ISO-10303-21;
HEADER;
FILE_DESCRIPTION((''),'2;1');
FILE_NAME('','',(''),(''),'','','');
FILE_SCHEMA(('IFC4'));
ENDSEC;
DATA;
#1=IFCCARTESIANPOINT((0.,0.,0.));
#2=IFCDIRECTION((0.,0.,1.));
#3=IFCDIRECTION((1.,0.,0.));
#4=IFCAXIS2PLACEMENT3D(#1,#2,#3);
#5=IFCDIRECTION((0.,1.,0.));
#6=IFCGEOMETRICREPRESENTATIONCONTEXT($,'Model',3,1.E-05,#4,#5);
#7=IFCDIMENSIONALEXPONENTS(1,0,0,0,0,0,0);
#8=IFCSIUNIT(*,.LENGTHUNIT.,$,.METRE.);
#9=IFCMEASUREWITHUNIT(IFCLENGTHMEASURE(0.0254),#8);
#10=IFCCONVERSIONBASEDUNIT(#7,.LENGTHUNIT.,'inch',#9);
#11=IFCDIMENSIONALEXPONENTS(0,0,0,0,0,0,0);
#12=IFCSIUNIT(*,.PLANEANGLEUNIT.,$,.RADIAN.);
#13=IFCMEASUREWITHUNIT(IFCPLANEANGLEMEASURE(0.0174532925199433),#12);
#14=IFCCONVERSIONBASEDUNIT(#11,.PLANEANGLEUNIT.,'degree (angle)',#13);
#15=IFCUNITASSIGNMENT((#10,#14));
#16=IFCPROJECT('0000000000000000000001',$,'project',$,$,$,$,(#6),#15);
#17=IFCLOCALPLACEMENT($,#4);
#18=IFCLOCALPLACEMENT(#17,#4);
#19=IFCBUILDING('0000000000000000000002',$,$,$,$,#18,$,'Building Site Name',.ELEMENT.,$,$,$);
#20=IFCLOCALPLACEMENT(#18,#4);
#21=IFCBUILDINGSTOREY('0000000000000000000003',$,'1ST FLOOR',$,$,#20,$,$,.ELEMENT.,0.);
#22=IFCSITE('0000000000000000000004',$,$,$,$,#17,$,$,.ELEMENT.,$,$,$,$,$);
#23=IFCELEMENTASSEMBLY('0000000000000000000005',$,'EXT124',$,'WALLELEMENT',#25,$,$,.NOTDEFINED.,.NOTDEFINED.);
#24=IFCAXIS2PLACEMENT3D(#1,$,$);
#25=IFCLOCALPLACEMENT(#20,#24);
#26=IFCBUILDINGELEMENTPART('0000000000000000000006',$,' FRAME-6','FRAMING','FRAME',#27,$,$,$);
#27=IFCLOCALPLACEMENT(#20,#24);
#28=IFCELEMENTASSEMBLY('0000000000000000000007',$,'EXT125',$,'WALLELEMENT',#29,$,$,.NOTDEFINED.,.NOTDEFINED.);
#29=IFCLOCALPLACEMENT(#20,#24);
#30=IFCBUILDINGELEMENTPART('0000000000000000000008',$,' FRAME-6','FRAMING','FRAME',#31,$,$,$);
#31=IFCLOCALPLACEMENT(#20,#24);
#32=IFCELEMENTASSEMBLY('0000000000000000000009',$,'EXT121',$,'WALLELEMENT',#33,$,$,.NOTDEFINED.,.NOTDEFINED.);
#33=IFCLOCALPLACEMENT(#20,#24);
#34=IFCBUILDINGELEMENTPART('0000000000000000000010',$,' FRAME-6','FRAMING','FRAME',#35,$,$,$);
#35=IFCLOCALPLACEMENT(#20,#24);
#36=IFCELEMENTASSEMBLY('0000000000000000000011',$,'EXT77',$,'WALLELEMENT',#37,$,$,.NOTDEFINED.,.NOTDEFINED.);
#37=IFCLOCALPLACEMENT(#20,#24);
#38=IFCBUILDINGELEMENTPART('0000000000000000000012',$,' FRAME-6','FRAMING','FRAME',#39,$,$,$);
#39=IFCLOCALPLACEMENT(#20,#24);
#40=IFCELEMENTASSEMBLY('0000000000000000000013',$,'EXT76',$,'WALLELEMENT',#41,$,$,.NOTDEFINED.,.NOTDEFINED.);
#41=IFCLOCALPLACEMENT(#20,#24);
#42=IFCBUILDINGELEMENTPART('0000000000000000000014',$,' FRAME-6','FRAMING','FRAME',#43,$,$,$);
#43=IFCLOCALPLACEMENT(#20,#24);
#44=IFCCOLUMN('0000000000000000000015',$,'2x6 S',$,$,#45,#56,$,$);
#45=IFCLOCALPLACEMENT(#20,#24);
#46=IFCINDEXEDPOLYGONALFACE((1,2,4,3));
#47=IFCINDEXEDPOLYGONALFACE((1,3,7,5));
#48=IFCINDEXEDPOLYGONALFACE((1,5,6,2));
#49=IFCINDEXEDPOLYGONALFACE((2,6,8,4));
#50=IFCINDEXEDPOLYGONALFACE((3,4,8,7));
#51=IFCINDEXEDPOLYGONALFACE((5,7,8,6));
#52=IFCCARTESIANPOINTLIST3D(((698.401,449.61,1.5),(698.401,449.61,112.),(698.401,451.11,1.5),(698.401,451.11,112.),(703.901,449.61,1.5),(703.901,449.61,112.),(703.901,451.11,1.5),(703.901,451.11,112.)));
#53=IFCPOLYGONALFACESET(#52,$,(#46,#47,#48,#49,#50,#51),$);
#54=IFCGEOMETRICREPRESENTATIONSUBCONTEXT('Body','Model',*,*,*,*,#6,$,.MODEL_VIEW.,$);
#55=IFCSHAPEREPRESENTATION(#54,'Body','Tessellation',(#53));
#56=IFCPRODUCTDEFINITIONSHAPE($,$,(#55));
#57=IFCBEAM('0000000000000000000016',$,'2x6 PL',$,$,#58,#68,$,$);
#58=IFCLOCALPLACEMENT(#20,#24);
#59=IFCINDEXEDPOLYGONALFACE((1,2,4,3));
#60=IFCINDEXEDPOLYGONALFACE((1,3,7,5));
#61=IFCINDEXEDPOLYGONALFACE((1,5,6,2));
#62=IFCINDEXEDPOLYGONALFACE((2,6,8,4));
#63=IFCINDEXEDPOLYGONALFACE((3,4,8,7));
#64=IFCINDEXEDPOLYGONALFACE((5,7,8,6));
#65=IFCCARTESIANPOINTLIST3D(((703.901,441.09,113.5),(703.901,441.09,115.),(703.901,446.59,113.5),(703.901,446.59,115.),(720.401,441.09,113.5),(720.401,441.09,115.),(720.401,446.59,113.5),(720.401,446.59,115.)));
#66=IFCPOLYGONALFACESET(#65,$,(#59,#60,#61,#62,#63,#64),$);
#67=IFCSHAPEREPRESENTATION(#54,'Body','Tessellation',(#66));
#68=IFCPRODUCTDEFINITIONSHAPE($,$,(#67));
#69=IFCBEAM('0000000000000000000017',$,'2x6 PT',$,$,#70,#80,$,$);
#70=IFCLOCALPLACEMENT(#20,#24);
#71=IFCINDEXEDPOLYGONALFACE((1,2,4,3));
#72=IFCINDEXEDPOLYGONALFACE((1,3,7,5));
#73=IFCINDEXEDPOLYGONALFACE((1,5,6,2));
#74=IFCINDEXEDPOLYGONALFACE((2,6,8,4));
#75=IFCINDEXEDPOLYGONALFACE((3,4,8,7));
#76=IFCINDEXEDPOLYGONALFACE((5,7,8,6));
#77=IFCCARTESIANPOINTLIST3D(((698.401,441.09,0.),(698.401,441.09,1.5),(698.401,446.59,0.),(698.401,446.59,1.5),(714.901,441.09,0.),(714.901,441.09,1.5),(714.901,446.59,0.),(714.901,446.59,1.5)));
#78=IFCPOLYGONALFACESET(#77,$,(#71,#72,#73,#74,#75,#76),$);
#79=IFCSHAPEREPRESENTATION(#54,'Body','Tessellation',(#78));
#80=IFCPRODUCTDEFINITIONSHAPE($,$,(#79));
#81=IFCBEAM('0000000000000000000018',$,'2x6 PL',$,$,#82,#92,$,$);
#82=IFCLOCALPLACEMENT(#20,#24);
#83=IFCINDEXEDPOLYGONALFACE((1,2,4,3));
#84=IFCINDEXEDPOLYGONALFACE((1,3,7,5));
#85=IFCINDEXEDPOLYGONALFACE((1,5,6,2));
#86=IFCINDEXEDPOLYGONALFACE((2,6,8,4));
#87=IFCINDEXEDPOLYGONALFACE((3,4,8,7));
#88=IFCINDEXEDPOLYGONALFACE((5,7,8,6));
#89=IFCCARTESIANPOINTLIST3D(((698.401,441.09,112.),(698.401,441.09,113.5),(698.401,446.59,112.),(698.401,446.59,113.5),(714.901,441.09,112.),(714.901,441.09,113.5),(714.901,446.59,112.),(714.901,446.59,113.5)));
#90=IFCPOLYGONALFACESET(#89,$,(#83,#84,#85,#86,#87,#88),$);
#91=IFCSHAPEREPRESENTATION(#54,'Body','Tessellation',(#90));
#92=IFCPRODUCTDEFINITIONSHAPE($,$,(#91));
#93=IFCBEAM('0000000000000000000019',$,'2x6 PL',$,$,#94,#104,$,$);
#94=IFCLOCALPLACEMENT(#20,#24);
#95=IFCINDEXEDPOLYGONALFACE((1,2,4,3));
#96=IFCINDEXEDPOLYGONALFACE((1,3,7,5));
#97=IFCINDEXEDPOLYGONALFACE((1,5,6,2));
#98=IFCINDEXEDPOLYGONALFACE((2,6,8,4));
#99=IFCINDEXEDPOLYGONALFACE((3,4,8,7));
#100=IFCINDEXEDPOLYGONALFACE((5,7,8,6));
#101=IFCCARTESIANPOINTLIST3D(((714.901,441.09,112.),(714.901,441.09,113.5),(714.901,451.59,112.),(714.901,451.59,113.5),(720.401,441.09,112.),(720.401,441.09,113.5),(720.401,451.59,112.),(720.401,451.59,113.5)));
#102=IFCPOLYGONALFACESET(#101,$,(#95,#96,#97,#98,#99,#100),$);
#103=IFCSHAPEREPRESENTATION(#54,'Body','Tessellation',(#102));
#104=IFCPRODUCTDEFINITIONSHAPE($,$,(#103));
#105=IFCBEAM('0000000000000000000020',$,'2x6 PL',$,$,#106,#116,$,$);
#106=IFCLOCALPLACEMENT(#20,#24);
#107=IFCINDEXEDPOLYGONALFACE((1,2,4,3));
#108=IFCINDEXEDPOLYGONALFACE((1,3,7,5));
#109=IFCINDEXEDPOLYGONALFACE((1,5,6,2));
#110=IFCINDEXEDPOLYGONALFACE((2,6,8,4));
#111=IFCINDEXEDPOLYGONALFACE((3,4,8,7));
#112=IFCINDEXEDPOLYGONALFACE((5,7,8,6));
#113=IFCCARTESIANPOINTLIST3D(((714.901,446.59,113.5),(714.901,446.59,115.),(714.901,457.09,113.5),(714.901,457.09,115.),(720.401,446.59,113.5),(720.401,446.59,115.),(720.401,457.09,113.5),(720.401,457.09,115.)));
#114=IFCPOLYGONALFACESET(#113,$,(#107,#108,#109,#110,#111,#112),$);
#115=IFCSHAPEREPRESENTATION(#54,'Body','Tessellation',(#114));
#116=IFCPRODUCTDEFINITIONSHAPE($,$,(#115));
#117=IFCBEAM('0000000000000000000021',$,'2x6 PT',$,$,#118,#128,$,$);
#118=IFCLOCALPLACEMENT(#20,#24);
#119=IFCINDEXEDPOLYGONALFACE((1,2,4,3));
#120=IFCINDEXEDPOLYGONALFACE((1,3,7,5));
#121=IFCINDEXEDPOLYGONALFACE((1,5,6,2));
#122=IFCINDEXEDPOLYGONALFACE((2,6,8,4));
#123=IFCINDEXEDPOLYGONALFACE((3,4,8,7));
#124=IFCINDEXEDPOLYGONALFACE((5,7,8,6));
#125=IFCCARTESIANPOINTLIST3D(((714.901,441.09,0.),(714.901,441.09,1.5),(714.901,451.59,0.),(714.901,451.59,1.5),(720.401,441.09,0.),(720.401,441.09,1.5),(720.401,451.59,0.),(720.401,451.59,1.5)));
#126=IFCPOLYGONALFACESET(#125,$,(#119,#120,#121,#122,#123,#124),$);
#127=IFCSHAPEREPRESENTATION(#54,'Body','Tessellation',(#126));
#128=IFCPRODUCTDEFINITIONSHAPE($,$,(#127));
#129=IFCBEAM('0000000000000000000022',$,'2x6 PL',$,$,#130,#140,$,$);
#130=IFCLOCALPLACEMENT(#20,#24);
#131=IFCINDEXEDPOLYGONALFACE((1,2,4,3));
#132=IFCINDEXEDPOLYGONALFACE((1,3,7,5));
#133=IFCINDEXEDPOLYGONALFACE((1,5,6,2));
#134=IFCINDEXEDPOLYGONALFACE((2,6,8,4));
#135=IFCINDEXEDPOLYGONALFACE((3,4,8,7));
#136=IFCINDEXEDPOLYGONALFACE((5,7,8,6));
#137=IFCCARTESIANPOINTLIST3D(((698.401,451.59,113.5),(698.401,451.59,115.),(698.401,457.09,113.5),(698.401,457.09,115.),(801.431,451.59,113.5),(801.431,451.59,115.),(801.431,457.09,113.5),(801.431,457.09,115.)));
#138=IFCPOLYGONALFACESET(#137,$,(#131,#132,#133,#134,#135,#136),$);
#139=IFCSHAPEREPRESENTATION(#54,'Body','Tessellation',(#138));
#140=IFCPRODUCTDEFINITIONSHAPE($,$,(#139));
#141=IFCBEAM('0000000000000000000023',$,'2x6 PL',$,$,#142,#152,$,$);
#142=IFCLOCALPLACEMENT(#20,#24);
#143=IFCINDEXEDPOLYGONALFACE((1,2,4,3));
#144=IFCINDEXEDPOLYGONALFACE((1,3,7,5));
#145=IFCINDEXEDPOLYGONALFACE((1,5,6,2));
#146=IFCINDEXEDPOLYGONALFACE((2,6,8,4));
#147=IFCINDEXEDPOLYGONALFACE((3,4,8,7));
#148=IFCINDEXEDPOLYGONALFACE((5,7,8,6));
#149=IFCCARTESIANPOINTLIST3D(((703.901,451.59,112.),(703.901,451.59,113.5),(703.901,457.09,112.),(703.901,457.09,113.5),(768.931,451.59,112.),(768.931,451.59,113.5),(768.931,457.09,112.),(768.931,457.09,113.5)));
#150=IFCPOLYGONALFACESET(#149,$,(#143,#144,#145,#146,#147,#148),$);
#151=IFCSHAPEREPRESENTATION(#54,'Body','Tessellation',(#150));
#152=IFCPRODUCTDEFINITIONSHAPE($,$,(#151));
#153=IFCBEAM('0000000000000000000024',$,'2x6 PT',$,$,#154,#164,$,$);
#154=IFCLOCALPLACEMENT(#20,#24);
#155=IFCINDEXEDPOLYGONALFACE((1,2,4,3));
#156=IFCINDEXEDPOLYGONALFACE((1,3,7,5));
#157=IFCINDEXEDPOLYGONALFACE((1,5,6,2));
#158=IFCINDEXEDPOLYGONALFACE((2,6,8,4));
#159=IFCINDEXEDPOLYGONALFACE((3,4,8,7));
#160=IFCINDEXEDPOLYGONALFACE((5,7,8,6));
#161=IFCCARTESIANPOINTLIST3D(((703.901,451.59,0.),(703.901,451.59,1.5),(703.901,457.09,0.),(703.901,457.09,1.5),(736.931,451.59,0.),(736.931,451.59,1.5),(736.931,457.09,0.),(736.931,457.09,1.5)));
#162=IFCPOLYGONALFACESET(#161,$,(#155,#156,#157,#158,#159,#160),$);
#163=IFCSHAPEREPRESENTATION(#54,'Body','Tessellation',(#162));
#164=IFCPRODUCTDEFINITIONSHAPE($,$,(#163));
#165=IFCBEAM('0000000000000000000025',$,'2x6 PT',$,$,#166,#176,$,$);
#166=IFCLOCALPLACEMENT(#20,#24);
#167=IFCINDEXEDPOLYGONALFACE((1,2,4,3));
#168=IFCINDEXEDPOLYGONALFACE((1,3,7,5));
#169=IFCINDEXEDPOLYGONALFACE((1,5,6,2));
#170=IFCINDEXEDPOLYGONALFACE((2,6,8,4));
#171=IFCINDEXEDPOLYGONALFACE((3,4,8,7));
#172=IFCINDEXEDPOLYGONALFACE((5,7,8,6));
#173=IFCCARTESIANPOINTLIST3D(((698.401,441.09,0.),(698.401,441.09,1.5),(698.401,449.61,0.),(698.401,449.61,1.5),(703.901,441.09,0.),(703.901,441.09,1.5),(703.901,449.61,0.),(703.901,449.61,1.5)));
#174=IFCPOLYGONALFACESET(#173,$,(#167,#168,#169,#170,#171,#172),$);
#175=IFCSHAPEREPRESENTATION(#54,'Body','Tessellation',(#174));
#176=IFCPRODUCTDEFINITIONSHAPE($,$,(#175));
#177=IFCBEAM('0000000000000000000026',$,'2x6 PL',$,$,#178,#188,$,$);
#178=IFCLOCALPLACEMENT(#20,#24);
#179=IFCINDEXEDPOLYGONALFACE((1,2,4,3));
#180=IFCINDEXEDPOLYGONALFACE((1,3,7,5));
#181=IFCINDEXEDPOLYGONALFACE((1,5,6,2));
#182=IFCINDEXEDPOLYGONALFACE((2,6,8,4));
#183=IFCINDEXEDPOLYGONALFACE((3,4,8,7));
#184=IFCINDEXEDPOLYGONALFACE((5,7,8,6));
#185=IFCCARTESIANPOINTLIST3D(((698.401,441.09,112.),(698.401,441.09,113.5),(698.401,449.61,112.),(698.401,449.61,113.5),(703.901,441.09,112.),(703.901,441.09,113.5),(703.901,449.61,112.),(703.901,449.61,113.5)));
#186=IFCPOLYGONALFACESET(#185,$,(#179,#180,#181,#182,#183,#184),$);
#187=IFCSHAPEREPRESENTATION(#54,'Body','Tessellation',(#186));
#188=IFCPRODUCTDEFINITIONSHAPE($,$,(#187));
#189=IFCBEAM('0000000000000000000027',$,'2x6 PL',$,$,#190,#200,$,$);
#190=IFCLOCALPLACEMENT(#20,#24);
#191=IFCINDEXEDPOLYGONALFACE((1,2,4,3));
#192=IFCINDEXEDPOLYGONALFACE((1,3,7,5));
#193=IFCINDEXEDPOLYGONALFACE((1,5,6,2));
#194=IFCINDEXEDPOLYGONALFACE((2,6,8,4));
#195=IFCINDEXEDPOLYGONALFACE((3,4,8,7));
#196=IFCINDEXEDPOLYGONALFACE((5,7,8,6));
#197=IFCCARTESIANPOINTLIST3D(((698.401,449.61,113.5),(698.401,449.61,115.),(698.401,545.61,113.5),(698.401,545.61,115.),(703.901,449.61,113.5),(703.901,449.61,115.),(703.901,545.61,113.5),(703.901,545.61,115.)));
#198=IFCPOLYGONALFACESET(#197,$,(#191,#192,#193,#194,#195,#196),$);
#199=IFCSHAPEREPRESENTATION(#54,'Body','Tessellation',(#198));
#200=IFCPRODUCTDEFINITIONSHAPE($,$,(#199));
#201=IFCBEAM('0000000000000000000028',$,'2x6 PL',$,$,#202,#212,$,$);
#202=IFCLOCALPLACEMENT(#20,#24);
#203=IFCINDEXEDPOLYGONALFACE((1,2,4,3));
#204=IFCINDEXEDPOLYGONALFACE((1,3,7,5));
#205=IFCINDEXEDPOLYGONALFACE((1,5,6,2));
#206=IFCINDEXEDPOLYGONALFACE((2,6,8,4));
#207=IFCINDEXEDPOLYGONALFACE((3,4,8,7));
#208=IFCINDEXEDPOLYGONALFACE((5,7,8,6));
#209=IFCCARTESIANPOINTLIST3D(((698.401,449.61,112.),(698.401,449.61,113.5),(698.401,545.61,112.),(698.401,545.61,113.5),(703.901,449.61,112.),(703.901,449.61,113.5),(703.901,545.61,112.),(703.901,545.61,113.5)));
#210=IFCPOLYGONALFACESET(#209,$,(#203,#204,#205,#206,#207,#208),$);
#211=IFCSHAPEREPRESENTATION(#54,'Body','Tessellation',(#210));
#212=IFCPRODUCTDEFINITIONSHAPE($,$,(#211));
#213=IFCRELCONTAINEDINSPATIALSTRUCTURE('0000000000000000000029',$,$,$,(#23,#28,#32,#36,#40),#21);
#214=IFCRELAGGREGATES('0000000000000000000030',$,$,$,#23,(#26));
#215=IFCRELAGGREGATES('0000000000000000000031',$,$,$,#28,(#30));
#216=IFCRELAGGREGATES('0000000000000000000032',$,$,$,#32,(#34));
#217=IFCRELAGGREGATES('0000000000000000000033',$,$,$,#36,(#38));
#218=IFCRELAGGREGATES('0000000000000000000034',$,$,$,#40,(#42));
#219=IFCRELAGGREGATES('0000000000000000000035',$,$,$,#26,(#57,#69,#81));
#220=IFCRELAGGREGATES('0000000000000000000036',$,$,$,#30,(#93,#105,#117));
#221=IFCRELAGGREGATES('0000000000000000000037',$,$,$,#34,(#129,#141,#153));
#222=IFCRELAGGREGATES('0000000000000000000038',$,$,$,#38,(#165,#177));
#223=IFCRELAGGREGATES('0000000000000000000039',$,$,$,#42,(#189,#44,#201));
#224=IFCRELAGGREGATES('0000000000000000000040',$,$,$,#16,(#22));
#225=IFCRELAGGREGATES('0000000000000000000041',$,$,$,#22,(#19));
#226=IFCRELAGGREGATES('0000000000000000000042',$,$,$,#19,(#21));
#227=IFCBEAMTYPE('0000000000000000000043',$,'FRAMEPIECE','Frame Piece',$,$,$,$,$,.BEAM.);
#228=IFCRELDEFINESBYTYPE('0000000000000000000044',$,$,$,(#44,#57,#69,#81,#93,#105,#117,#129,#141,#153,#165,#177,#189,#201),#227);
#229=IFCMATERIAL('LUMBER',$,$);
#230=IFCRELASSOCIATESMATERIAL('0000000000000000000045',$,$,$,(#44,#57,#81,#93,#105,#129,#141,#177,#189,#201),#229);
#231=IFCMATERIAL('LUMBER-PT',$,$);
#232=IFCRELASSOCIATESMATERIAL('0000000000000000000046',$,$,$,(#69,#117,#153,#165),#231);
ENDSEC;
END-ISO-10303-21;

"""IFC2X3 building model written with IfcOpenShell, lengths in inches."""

from ifc_helpers import new_model, entity, si_unit, converted_unit, direction, frame, frame_2d, origin_with_axes, place, context, subcontext, project, spatial, rectangle, extrude, material, type_object, element, aggregate, save


model = new_model("IFC2X3")

# Units and contexts
model_context = context("Model", 3, precision=1e-05, world=origin_with_axes(), true_north=direction((0.0, 1.0, 0.0)))
body_context = subcontext(model_context, "Body", "Model", "MODEL_VIEW")
ifc_project = project(units=[converted_unit("LENGTHUNIT", "inch", entity("IfcLengthMeasure", 0.0254), si_unit("LENGTHUNIT", "METRE"), dimensions=[1, 0, 0, 0, 0, 0, 0]), converted_unit("PLANEANGLEUNIT", "degree (angle)", entity("IfcPlaneAngleMeasure", 0.0174532925199433), si_unit("PLANEANGLEUNIT", "RADIAN"), dimensions=[0, 0, 0, 0, 0, 0, 0])], contexts=[model_context])

# Site, building, storey
site_placement = place(None, origin_with_axes())
site = spatial("IfcSite", under=ifc_project, at=site_placement, CompositionType="ELEMENT")
building_placement = place(site_placement, origin_with_axes())
building = spatial("IfcBuilding", under=site, at=building_placement, LongName="Building Site Name", CompositionType="ELEMENT")
storey_placement = place(building_placement, origin_with_axes())
storey = spatial("IfcBuildingStorey", under=building, at=storey_placement, Name="1ST FLOOR", CompositionType="ELEMENT", Elevation=0.0)

# Element assemblies, building element parts
assembly_1_placement = place(storey_placement, origin_with_axes())
assembly_1 = element("IfcElementAssembly", 1, at=assembly_1_placement, inside=storey, Name="EXT124", ObjectType="WALLELEMENT", AssemblyPlace="NOTDEFINED", PredefinedType="NOTDEFINED")
building_element_part_1 = element("IfcBuildingElementPart", 2, Name=" FRAME-6", Description="FRAMING", ObjectType="FRAME")
aggregate(assembly_1, [building_element_part_1])
ifc_material_1 = material(Name="LUMBER")
beam_type = type_object("IfcBeamType", Name="FRAMEPIECE", Description="Frame Piece", PredefinedType="BEAM")
assembly_2_placement = place(storey_placement, origin_with_axes())
assembly_2 = element("IfcElementAssembly", 3, at=assembly_2_placement, inside=storey, Name="EXT125", ObjectType="WALLELEMENT", AssemblyPlace="NOTDEFINED", PredefinedType="NOTDEFINED")
building_element_part_2 = element("IfcBuildingElementPart", 4, Name=" FRAME-6", Description="FRAMING", ObjectType="FRAME")
aggregate(assembly_2, [building_element_part_2])
assembly_3_placement = place(storey_placement, origin_with_axes())
assembly_3 = element("IfcElementAssembly", 5, at=assembly_3_placement, inside=storey, Name="EXT121", ObjectType="WALLELEMENT", AssemblyPlace="NOTDEFINED", PredefinedType="NOTDEFINED")
building_element_part_3 = element("IfcBuildingElementPart", 6, Name=" FRAME-6", Description="FRAMING", ObjectType="FRAME")
aggregate(assembly_3, [building_element_part_3])
assembly_4_placement = place(storey_placement, origin_with_axes())
assembly_4 = element("IfcElementAssembly", 7, at=assembly_4_placement, inside=storey, Name="EXT77", ObjectType="WALLELEMENT", AssemblyPlace="NOTDEFINED", PredefinedType="NOTDEFINED")
building_element_part_4 = element("IfcBuildingElementPart", 8, Name=" FRAME-6", Description="FRAMING", ObjectType="FRAME")
aggregate(assembly_4, [building_element_part_4])

# Element assembly, building element part, column
assembly_5_placement = place(storey_placement, origin_with_axes())
assembly_5 = element("IfcElementAssembly", 9, at=assembly_5_placement, inside=storey, Name="EXT76", ObjectType="WALLELEMENT", AssemblyPlace="NOTDEFINED", PredefinedType="NOTDEFINED")
building_element_part_5 = element("IfcBuildingElementPart", 10, Name=" FRAME-6", Description="FRAMING", ObjectType="FRAME")
aggregate(assembly_5, [building_element_part_5])
column_1_placement = place(assembly_5_placement, frame((701.151, 450.36, 1.5), z_axis=(0.0, 0.0, 1.0), x_axis=(0.0, 1.0, 0.0)))
column_1 = element("IfcColumn", 11, at=column_1_placement, type_object=beam_type, material=ifc_material_1, Name="2x6 S", context=body_context, shape_type="SweptSolid", body=[
    extrude(rectangle(XDim=1.5, YDim=5.5, at=frame_2d((0.0, 0.0), x_axis=(-1.0, 0.0))), frame((0.0, 0.0, 0.0), z_axis=(0.0, 0.0, 1.0), x_axis=(1.0, 0.0, 0.0)), (0.0, 0.0, 1.0), 110.5),
])

# Beams
beam_1_placement = place(assembly_1_placement, frame((703.901, 443.84, 114.25), z_axis=(1.0, 0.0, 0.0), x_axis=(0.0, 0.0, -1.0)))
beam_1 = element("IfcBeam", 12, at=beam_1_placement, type_object=beam_type, material=ifc_material_1, Name="2x6 PL", context=body_context, shape_type="SweptSolid", body=[
    extrude(rectangle(XDim=1.5, YDim=5.5, at=frame_2d((0.0, 0.0), x_axis=(-1.0, 0.0))), origin_with_axes(), (0.0, 0.0, 1.0), 16.5),
])
ifc_material_2 = material(Name="LUMBER-PT")
beam_2_placement = place(assembly_1_placement, frame((714.901, 443.84, 0.75), z_axis=(-1.0, 0.0, 0.0), x_axis=(0.0, 0.0, 1.0)))
beam_2 = element("IfcBeam", 13, at=beam_2_placement, type_object=beam_type, material=ifc_material_2, Name="2x6 PT", context=body_context, shape_type="SweptSolid", body=[
    extrude(rectangle(XDim=1.5, YDim=5.5, at=frame_2d((0.0, 0.0), x_axis=(-1.0, 0.0))), origin_with_axes(), (0.0, 0.0, 1.0), 16.5),
])
beam_3_placement = place(assembly_1_placement, frame((698.401, 443.84, 112.75), z_axis=(1.0, 0.0, 0.0), x_axis=(0.0, 0.0, -1.0)))
beam_3 = element("IfcBeam", 14, at=beam_3_placement, type_object=beam_type, material=ifc_material_1, Name="2x6 PL", context=body_context, shape_type="SweptSolid", body=[
    extrude(rectangle(XDim=1.5, YDim=5.5, at=frame_2d((0.0, 0.0), x_axis=(-1.0, 0.0))), origin_with_axes(), (0.0, 0.0, 1.0), 16.5),
])
aggregate(building_element_part_1, [beam_1, beam_2, beam_3])
beam_4_placement = place(assembly_2_placement, frame((717.651, 441.09, 112.75), z_axis=(0.0, 1.0, 0.0), x_axis=(0.0, 0.0, -1.0)))
beam_4 = element("IfcBeam", 15, at=beam_4_placement, type_object=beam_type, material=ifc_material_1, Name="2x6 PL", context=body_context, shape_type="SweptSolid", body=[
    extrude(rectangle(XDim=1.5, YDim=5.5, at=frame_2d((0.0, 0.0), x_axis=(-1.0, 0.0))), origin_with_axes(), (0.0, 0.0, 1.0), 10.5),
])
beam_5_placement = place(assembly_2_placement, frame((717.651, 446.59, 114.25), z_axis=(0.0, 1.0, 0.0), x_axis=(0.0, 0.0, -1.0)))
beam_5 = element("IfcBeam", 16, at=beam_5_placement, type_object=beam_type, material=ifc_material_1, Name="2x6 PL", context=body_context, shape_type="SweptSolid", body=[
    extrude(rectangle(XDim=1.5, YDim=5.5, at=frame_2d((0.0, 0.0), x_axis=(-1.0, 0.0))), origin_with_axes(), (0.0, 0.0, 1.0), 10.5),
])
beam_6_placement = place(assembly_2_placement, frame((717.651, 451.59, 0.75), z_axis=(0.0, -1.0, 0.0), x_axis=(0.0, 0.0, 1.0)))
beam_6 = element("IfcBeam", 17, at=beam_6_placement, type_object=beam_type, material=ifc_material_2, Name="2x6 PT", context=body_context, shape_type="SweptSolid", body=[
    extrude(rectangle(XDim=1.5, YDim=5.5, at=frame_2d((0.0, 0.0), x_axis=(-1.0, 0.0))), origin_with_axes(), (0.0, 0.0, 1.0), 10.5),
])
aggregate(building_element_part_2, [beam_4, beam_5, beam_6])
beam_7_placement = place(assembly_3_placement, frame((698.401, 454.34, 114.25), z_axis=(1.0, 0.0, 0.0), x_axis=(0.0, 0.0, -1.0)))
beam_7 = element("IfcBeam", 18, at=beam_7_placement, type_object=beam_type, material=ifc_material_1, Name="2x6 PL", context=body_context, shape_type="SweptSolid", body=[
    extrude(rectangle(XDim=1.5, YDim=5.5, at=frame_2d((0.0, 0.0), x_axis=(-1.0, 0.0))), origin_with_axes(), (0.0, 0.0, 1.0), 103.03),
])
beam_8_placement = place(assembly_3_placement, frame((703.901, 454.34, 112.75), z_axis=(1.0, 0.0, 0.0), x_axis=(0.0, 0.0, -1.0)))
beam_8 = element("IfcBeam", 19, at=beam_8_placement, type_object=beam_type, material=ifc_material_1, Name="2x6 PL", context=body_context, shape_type="SweptSolid", body=[
    extrude(rectangle(XDim=1.5, YDim=5.5, at=frame_2d((0.0, 0.0), x_axis=(-1.0, 0.0))), frame((0.0, 0.0, 0.0), z_axis=(0.0, 0.0, 1.0), x_axis=(1.0, 0.0, 0.0)), (0.0, 0.0, 1.0), 65.03),
])
beam_9_placement = place(assembly_3_placement, frame((736.931, 454.34, 0.75), z_axis=(-1.0, 0.0, 0.0), x_axis=(0.0, 0.0, 1.0)))
beam_9 = element("IfcBeam", 20, at=beam_9_placement, type_object=beam_type, material=ifc_material_2, Name="2x6 PT", context=body_context, shape_type="SweptSolid", body=[
    extrude(rectangle(XDim=1.5, YDim=5.5, at=frame_2d((0.0, 0.0), x_axis=(-1.0, 0.0))), origin_with_axes(), (0.0, 0.0, 1.0), 33.03),
])
aggregate(building_element_part_3, [beam_7, beam_8, beam_9])
beam_10_placement = place(assembly_4_placement, frame((701.151, 449.61, 0.75), z_axis=(0.0, -1.0, 0.0), x_axis=(0.0, 0.0, 1.0)))
beam_10 = element("IfcBeam", 21, at=beam_10_placement, type_object=beam_type, material=ifc_material_2, Name="2x6 PT", context=body_context, shape_type="SweptSolid", body=[
    extrude(rectangle(XDim=1.5, YDim=5.5, at=frame_2d((0.0, 0.0), x_axis=(-1.0, 0.0))), origin_with_axes(), (0.0, 0.0, 1.0), 8.52),
])
beam_11_placement = place(assembly_4_placement, frame((701.151, 441.09, 112.75), z_axis=(0.0, 1.0, 0.0), x_axis=(0.0, 0.0, -1.0)))
beam_11 = element("IfcBeam", 22, at=beam_11_placement, type_object=beam_type, material=ifc_material_1, Name="2x6 PL", context=body_context, shape_type="SweptSolid", body=[
    extrude(rectangle(XDim=1.5, YDim=5.5, at=frame_2d((0.0, 0.0), x_axis=(-1.0, 0.0))), frame((0.0, 0.0, 0.0), z_axis=(0.0, 0.0, 1.0), x_axis=(1.0, 0.0, 0.0)), (0.0, 0.0, 1.0), 8.52),
])
aggregate(building_element_part_4, [beam_10, beam_11])
beam_12_placement = place(assembly_5_placement, frame((701.151, 449.61, 114.25), z_axis=(0.0, 1.0, 0.0), x_axis=(0.0, 0.0, -1.0)))
beam_12 = element("IfcBeam", 23, at=beam_12_placement, type_object=beam_type, material=ifc_material_1, Name="2x6 PL", context=body_context, shape_type="SweptSolid", body=[
    extrude(rectangle(XDim=1.5, YDim=5.5, at=frame_2d((0.0, 0.0), x_axis=(-1.0, 0.0))), origin_with_axes(), (0.0, 0.0, 1.0), 96.0),
])
beam_13_placement = place(assembly_5_placement, frame((701.151, 449.61, 112.75), z_axis=(0.0, 1.0, 0.0), x_axis=(0.0, 0.0, -1.0)))
beam_13 = element("IfcBeam", 24, at=beam_13_placement, type_object=beam_type, material=ifc_material_1, Name="2x6 PL", context=body_context, shape_type="SweptSolid", body=[
    extrude(rectangle(XDim=1.5, YDim=5.5, at=frame_2d((0.0, 0.0), x_axis=(-1.0, 0.0))), origin_with_axes(), (0.0, 0.0, 1.0), 96.0),
])
aggregate(building_element_part_5, [beam_12, column_1, beam_13])

save(model, "model.ifc")
